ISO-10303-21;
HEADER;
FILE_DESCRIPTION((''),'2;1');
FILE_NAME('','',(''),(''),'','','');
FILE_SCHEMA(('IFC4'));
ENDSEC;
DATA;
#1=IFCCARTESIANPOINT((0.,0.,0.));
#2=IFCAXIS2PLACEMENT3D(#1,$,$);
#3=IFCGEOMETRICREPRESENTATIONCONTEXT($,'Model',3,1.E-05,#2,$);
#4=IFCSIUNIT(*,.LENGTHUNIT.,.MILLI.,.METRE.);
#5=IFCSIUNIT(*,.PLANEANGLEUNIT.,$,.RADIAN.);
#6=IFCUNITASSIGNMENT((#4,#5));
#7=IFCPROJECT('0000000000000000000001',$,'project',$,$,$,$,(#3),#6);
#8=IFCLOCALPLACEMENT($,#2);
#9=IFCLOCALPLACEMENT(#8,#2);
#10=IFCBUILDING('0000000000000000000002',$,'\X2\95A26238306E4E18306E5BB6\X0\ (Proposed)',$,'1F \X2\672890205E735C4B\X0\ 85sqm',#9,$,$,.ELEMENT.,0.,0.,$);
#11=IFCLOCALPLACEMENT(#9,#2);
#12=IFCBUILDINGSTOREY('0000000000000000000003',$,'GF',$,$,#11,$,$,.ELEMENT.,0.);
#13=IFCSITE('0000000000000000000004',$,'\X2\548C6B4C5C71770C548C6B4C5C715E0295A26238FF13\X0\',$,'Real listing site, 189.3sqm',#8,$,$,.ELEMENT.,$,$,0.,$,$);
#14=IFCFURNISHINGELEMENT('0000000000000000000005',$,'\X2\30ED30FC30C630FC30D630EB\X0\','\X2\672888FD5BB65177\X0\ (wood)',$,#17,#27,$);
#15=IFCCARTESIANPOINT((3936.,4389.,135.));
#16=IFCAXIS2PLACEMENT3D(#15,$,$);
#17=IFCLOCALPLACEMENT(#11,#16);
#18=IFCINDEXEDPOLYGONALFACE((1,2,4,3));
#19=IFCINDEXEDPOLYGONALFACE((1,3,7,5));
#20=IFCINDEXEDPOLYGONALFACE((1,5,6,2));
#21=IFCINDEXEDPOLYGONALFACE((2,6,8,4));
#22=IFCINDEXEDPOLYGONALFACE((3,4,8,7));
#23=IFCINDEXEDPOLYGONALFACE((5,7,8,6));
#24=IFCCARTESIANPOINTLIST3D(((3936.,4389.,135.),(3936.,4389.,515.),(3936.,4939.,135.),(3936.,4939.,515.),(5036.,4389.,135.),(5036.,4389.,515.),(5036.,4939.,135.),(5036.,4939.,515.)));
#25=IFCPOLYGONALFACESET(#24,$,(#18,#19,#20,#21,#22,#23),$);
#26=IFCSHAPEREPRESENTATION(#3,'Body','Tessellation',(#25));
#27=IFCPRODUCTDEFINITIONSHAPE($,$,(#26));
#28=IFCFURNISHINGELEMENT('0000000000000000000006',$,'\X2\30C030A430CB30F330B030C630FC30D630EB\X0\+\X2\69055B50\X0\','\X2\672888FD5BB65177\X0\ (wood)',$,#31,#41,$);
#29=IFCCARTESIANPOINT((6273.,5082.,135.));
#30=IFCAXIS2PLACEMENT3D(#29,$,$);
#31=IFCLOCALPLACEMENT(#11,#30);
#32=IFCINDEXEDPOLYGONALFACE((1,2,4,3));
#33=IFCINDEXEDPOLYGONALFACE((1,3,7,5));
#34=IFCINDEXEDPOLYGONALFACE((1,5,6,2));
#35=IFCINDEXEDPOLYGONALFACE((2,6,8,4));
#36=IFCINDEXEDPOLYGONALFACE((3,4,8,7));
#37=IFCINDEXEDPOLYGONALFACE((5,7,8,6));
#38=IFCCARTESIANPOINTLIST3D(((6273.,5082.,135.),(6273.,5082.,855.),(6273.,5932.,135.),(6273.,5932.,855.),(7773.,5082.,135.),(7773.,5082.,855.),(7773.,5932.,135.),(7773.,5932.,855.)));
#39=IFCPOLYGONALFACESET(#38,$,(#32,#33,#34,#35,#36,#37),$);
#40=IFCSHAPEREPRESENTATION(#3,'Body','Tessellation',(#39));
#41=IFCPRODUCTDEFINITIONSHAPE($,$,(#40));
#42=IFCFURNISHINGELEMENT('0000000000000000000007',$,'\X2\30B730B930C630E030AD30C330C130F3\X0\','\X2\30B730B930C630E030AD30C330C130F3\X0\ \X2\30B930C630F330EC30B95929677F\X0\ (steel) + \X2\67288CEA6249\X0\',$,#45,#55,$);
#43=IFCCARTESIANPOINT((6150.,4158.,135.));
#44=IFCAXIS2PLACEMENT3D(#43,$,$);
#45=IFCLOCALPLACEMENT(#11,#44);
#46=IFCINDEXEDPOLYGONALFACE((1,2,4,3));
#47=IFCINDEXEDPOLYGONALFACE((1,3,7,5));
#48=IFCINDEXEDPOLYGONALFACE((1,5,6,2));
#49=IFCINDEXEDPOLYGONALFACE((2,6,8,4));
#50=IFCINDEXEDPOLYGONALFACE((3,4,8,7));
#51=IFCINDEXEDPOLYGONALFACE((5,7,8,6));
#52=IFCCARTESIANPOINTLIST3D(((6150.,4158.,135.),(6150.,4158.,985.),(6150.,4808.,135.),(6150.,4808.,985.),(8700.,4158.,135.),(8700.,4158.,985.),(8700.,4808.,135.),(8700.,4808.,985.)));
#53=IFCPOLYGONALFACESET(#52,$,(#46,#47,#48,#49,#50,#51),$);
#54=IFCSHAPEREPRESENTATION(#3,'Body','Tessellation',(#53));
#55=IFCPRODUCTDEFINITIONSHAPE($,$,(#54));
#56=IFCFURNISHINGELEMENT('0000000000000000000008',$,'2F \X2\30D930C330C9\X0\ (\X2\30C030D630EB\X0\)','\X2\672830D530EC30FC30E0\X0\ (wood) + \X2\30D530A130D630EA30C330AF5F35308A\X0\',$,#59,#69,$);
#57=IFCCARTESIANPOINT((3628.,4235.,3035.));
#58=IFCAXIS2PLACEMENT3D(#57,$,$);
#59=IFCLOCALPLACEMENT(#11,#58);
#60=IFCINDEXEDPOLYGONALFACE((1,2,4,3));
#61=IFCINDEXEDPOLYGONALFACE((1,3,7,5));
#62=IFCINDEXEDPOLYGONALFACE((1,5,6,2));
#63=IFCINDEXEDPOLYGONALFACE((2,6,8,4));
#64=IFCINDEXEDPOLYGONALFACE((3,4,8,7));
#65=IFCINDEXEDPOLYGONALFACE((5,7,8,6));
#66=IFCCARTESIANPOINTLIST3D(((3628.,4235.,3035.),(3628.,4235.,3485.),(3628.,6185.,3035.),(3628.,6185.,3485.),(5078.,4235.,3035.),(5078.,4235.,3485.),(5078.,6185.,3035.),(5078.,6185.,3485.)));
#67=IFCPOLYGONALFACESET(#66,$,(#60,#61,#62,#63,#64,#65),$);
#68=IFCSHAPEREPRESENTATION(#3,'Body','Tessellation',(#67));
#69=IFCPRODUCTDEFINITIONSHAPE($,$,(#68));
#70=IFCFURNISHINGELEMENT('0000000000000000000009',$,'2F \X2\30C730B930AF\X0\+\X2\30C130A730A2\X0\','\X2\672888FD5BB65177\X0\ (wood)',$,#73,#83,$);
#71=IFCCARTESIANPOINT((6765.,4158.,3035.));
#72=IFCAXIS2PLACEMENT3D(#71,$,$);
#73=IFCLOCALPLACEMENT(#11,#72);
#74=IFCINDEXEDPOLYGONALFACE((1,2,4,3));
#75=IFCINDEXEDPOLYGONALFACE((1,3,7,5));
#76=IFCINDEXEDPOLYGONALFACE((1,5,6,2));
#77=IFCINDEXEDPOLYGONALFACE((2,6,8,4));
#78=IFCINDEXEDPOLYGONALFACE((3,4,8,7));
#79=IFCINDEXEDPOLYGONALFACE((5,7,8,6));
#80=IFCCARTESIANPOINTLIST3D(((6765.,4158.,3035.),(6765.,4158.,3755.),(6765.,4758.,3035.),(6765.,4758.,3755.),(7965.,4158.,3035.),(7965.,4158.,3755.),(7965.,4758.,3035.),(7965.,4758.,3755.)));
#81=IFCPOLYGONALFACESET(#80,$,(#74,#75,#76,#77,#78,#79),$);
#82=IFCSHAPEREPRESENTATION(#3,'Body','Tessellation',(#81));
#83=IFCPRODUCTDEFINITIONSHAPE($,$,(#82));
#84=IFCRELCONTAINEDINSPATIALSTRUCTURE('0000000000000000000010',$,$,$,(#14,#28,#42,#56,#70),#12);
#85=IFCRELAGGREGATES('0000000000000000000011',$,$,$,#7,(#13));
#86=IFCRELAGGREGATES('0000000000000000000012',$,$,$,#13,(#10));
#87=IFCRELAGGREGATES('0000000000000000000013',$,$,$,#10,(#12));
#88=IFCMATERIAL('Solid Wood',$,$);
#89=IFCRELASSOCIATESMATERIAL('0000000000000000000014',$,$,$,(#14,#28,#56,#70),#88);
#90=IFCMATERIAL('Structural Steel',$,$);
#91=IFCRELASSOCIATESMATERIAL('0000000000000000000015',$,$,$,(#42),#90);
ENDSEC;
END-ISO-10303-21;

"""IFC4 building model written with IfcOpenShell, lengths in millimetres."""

from ifc_helpers import new_model, si_unit, frame, frame_2d, origin, place, context, project, spatial, rectangle, extrude, material, element, save


model = new_model("IFC4")

# Units and contexts
model_context = context("Model", 3, precision=1e-05, world=origin())
ifc_project = project(units=[si_unit("LENGTHUNIT", "METRE", prefix="MILLI"), si_unit("PLANEANGLEUNIT", "RADIAN")], contexts=[model_context])

# Site, building, storey
site_placement = place(None, origin())
site = spatial("IfcSite", under=ifc_project, at=site_placement, Name="和歌山県和歌山市関戸３", ObjectType="Real listing site, 189.3sqm", CompositionType="ELEMENT", RefElevation=0.0)
building_placement = place(site_placement, origin())
building = spatial("IfcBuilding", under=site, at=building_placement, Name="関戸の丘の家 (Proposed)", ObjectType="1F 木造平屋 85sqm", CompositionType="ELEMENT", ElevationOfRefHeight=0.0, ElevationOfTerrain=0.0)
storey_placement = place(building_placement, origin())
storey = spatial("IfcBuildingStorey", under=building, at=storey_placement, Name="GF", CompositionType="ELEMENT", Elevation=0.0)

# Shared definitions
ifc_material_1 = material(Name="Solid Wood")

# Shared definitions
ifc_material_2 = material(Name="Structural Steel")

# Furnishing elements
furnishing_1_placement = place(storey_placement, frame((3936.0, 4389.0, 135.0)))
element("IfcFurnishingElement", 1, at=furnishing_1_placement, inside=storey, material=ifc_material_1, Name="ローテーブル", Description="木製家具 (wood)", context=model_context, shape_type="SweptSolid", body=[
    extrude(rectangle(XDim=1100.0, YDim=550.0, at=frame_2d((550.0, 275.0))), frame((3936.0, 4389.0, 135.0)), (0.0, 0.0, 1.0), 380.0),
])
furnishing_2_placement = place(storey_placement, frame((6273.0, 5082.0, 135.0)))
element("IfcFurnishingElement", 2, at=furnishing_2_placement, inside=storey, material=ifc_material_1, Name="ダイニングテーブル+椅子", Description="木製家具 (wood)", context=model_context, shape_type="SweptSolid", body=[
    extrude(rectangle(XDim=1500.0, YDim=850.0, at=frame_2d((750.0, 425.0))), frame((6273.0, 5082.0, 135.0)), (0.0, 0.0, 1.0), 720.0),
])
furnishing_3_placement = place(storey_placement, frame((6150.0, 4158.0, 135.0)))
element("IfcFurnishingElement", 3, at=furnishing_3_placement, inside=storey, material=ifc_material_2, Name="システムキッチン", Description="システムキッチン ステンレス天板 (steel) + 木質扉", context=model_context, shape_type="SweptSolid", body=[
    extrude(rectangle(XDim=2550.0, YDim=650.0, at=frame_2d((1275.0, 325.0))), frame((6150.0, 4158.0, 135.0)), (0.0, 0.0, 1.0), 850.0),
])
furnishing_4_placement = place(storey_placement, frame((3628.0, 4235.0, 3035.0)))
element("IfcFurnishingElement", 4, at=furnishing_4_placement, inside=storey, material=ifc_material_1, Name="2F ベッド (ダブル)", Description="木フレーム (wood) + ファブリック張り", context=model_context, shape_type="SweptSolid", body=[
    extrude(rectangle(XDim=1450.0, YDim=1950.0, at=frame_2d((725.0, 975.0))), frame((3628.0, 4235.0, 3035.0)), (0.0, 0.0, 1.0), 450.0),
])
furnishing_5_placement = place(storey_placement, frame((6765.0, 4158.0, 3035.0)))
element("IfcFurnishingElement", 5, at=furnishing_5_placement, inside=storey, material=ifc_material_1, Name="2F デスク+チェア", Description="木製家具 (wood)", context=model_context, shape_type="SweptSolid", body=[
    extrude(rectangle(XDim=1200.0, YDim=600.0, at=frame_2d((600.0, 300.0))), frame((6765.0, 4158.0, 3035.0)), (0.0, 0.0, 1.0), 720.0),
])

save(model, "model.ifc")
